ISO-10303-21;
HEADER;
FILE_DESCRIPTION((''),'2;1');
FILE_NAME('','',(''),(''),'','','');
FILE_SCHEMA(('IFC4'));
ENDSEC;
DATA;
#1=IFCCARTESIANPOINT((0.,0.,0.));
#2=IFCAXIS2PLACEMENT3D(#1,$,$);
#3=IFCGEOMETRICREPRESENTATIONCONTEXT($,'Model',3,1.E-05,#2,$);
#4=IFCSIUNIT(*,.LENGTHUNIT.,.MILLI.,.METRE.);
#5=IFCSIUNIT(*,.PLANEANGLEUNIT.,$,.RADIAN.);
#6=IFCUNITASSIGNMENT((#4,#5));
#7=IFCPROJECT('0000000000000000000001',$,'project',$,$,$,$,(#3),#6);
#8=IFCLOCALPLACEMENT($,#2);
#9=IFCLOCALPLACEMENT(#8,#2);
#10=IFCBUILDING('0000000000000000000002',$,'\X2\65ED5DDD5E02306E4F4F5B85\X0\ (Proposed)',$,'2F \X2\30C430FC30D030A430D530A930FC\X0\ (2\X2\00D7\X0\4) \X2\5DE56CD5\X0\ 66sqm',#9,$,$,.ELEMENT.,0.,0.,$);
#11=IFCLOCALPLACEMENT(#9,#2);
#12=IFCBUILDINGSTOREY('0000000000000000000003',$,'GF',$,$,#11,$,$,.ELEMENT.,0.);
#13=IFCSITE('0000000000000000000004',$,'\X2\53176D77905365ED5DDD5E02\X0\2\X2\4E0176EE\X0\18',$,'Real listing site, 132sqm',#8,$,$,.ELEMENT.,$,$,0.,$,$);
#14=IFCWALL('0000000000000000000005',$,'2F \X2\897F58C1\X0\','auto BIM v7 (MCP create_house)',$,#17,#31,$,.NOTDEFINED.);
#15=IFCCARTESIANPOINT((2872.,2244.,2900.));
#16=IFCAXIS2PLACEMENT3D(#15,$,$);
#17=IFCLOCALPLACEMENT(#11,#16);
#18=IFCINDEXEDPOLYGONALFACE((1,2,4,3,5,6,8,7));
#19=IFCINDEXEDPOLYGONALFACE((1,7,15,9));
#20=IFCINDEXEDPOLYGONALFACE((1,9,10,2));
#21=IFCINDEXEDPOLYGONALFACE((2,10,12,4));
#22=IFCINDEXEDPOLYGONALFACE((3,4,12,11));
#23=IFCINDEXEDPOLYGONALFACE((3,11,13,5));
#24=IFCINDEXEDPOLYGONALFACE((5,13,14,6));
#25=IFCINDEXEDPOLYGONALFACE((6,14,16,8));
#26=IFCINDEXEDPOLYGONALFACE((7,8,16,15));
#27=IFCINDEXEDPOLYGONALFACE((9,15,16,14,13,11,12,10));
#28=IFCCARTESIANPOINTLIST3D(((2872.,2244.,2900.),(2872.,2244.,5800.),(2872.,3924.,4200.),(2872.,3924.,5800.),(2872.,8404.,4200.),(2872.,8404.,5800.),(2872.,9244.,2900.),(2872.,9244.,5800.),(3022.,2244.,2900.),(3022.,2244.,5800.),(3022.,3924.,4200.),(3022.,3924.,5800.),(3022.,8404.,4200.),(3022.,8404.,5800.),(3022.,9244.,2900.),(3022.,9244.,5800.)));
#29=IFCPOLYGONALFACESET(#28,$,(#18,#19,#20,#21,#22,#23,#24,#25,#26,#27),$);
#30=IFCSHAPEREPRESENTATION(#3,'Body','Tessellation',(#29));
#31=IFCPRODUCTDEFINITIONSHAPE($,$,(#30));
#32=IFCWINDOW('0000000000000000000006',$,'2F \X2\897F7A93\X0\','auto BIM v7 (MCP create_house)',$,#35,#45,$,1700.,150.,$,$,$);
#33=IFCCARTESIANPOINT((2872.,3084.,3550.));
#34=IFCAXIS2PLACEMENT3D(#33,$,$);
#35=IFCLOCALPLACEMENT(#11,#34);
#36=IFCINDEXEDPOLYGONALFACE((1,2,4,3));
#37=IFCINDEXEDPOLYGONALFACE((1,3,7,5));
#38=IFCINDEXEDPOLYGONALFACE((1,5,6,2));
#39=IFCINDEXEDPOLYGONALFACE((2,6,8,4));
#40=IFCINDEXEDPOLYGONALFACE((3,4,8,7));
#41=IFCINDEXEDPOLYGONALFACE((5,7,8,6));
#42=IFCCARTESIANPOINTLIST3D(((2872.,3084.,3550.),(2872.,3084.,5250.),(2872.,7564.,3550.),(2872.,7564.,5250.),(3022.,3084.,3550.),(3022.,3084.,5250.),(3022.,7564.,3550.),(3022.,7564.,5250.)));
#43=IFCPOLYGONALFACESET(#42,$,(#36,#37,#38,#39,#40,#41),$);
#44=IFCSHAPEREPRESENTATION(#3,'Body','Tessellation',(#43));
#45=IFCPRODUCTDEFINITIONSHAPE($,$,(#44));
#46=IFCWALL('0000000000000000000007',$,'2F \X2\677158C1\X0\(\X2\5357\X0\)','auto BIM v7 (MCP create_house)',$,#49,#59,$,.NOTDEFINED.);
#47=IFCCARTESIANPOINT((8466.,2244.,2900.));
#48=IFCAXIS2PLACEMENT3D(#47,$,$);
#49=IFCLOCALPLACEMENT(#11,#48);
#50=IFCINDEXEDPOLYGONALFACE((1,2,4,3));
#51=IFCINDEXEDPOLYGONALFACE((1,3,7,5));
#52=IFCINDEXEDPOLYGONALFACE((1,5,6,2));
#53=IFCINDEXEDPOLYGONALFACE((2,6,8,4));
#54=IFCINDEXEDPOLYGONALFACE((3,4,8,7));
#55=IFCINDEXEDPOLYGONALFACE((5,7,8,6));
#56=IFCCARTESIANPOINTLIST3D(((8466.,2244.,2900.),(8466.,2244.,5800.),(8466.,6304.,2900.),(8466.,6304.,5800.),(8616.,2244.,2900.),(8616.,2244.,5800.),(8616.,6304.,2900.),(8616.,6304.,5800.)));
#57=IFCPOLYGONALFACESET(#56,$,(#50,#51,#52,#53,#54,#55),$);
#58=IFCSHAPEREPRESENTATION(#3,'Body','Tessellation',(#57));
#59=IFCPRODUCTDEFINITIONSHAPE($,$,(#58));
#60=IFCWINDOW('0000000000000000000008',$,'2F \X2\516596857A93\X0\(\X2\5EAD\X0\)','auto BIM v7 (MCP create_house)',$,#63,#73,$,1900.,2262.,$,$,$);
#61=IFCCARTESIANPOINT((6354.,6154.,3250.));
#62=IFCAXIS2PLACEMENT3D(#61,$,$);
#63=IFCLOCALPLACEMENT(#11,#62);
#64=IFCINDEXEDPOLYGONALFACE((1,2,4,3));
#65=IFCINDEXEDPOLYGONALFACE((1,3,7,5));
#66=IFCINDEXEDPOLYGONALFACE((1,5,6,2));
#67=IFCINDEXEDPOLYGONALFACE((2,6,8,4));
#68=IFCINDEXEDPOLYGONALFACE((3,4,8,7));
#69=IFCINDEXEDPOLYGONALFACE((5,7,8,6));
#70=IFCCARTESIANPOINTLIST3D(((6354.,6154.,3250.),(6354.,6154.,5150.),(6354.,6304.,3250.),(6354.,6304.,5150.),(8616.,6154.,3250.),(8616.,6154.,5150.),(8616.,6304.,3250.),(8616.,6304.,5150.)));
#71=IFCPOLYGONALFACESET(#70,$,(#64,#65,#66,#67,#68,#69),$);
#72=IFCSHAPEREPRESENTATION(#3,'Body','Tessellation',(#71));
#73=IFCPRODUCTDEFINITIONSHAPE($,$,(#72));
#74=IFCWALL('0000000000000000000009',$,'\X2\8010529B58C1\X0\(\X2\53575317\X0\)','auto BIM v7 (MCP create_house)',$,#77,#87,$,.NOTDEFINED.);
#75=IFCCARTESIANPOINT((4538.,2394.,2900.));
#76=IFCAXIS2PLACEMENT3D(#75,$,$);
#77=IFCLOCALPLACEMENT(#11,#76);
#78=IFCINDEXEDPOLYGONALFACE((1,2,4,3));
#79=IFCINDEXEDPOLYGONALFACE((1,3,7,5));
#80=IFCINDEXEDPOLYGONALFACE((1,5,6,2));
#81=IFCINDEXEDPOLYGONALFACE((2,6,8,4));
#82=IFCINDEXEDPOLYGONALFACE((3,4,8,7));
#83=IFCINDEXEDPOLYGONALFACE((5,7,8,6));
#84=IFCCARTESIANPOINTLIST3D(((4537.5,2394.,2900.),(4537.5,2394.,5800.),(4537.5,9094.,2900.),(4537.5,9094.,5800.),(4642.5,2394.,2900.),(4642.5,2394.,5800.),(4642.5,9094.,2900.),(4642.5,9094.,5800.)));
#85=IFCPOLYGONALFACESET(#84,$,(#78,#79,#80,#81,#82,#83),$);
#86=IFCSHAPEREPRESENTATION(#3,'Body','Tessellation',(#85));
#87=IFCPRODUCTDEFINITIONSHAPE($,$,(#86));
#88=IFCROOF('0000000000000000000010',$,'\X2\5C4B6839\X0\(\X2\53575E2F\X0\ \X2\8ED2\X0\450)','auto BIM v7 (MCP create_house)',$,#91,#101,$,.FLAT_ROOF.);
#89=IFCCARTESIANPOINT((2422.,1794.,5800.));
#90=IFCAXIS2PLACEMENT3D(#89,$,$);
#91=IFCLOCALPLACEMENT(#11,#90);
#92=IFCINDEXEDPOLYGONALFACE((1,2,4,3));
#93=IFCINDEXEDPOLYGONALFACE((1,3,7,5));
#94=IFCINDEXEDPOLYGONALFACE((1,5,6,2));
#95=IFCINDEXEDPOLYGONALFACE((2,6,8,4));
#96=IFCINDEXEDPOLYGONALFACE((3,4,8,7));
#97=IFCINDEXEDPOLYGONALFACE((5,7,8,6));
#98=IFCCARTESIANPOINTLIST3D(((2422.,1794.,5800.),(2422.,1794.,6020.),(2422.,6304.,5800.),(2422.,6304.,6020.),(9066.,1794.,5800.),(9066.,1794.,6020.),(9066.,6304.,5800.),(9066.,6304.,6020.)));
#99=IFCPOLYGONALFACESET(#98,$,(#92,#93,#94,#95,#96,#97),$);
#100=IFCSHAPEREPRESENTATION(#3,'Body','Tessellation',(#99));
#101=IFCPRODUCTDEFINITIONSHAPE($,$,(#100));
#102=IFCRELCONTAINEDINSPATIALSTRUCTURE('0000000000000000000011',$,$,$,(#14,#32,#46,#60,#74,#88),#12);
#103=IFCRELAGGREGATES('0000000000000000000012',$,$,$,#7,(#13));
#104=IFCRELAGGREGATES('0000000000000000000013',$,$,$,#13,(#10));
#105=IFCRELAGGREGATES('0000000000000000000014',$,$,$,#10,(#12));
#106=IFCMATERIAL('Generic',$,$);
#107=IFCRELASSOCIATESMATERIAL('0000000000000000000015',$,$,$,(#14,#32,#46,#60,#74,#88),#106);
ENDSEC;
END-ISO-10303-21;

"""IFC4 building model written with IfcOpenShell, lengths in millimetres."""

from ifc_helpers import new_model, si_unit, frame, frame_2d, origin, place, context, project, spatial, rectangle, extrude, material, element, fill, save


model = new_model("IFC4")

# Units and contexts
model_context = context("Model", 3, precision=1e-05, world=origin())
ifc_project = project(units=[si_unit("LENGTHUNIT", "METRE", prefix="MILLI"), si_unit("PLANEANGLEUNIT", "RADIAN")], contexts=[model_context])

# Site, building, storey
site_placement = place(None, origin())
site = spatial("IfcSite", under=ifc_project, at=site_placement, Name="北海道旭川市2丁目18", ObjectType="Real listing site, 132sqm", CompositionType="ELEMENT", RefElevation=0.0)
building_placement = place(site_placement, origin())
building = spatial("IfcBuilding", under=site, at=building_placement, Name="旭川市の住宅 (Proposed)", ObjectType="2F ツーバイフォー (2×4) 工法 66sqm", CompositionType="ELEMENT", ElevationOfRefHeight=0.0, ElevationOfTerrain=0.0)
storey_placement = place(building_placement, origin())
storey = spatial("IfcBuildingStorey", under=building, at=storey_placement, Name="GF", CompositionType="ELEMENT", Elevation=0.0)

# Shared definitions
ifc_material = material(Name="Generic")

# Walls, openings, windows
wall_1_placement = place(storey_placement, frame((2872.0, 2244.0, 2900.0)))
wall_1 = element("IfcWall", 1, at=wall_1_placement, inside=storey, material=ifc_material, Name="2F 西壁", Description="auto BIM v7 (MCP create_house)", PredefinedType="NOTDEFINED", context=model_context, shape_type="SweptSolid", body=[
    extrude(rectangle(XDim=150.0, YDim=7000.0, at=frame_2d((75.0, 3500.0))), frame((2872.0, 2244.0, 2900.0)), (0.0, 0.0, 1.0), 2900.0),
])
opening_1_placement = place(storey_placement, frame((2872.0, 3084.0, 3550.0)))
opening_1 = element("IfcOpeningElement", 2, at=opening_1_placement, cuts=wall_1, PredefinedType="NOTDEFINED", context=model_context, shape_type="SweptSolid", body=[
    extrude(rectangle(XDim=150.0, YDim=4480.0, at=frame_2d((75.0, 2240.0))), frame((2872.0, 3084.0, 3550.0)), (0.0, 0.0, 1.0), 1700.0),
])
window_1_placement = place(storey_placement, frame((2872.0, 3084.0, 3550.0)))
window_1 = element("IfcWindow", 3, at=window_1_placement, inside=storey, material=ifc_material, Name="2F 西窓", Description="auto BIM v7 (MCP create_house)", OverallHeight=1700.0, OverallWidth=150.0, context=model_context, shape_type="SweptSolid", body=[
    extrude(rectangle(XDim=150.0, YDim=4480.0, at=frame_2d((75.0, 2240.0))), frame((2872.0, 3084.0, 3550.0)), (0.0, 0.0, 1.0), 1700.0),
])
fill(opening_1, window_1)
wall_2_placement = place(storey_placement, frame((8466.0, 2244.0, 2900.0)))
wall_2 = element("IfcWall", 4, at=wall_2_placement, inside=storey, material=ifc_material, Name="2F 東壁(南)", Description="auto BIM v7 (MCP create_house)", PredefinedType="NOTDEFINED", context=model_context, shape_type="SweptSolid", body=[
    extrude(rectangle(XDim=150.0, YDim=4060.0, at=frame_2d((75.0, 2030.0))), frame((8466.0, 2244.0, 2900.0)), (0.0, 0.0, 1.0), 2900.0),
])
opening_2_placement = place(storey_placement, frame((6354.0, 6154.0, 3250.0)))
opening_2 = element("IfcOpeningElement", 5, at=opening_2_placement, cuts=wall_2, PredefinedType="NOTDEFINED", context=model_context, shape_type="SweptSolid", body=[
    extrude(rectangle(XDim=2262.0, YDim=150.0, at=frame_2d((1131.0, 75.0))), frame((6354.0, 6154.0, 3250.0)), (0.0, 0.0, 1.0), 1900.0),
])
window_2_placement = place(storey_placement, frame((6354.0, 6154.0, 3250.0)))
window_2 = element("IfcWindow", 6, at=window_2_placement, inside=storey, material=ifc_material, Name="2F 入隅窓(庭)", Description="auto BIM v7 (MCP create_house)", OverallHeight=1900.0, OverallWidth=2262.0, context=model_context, shape_type="SweptSolid", body=[
    extrude(rectangle(XDim=2262.0, YDim=150.0, at=frame_2d((1131.0, 75.0))), frame((6354.0, 6154.0, 3250.0)), (0.0, 0.0, 1.0), 1900.0),
])
fill(opening_2, window_2)

# Wall
wall_3_placement = place(storey_placement, frame((4538.0, 2394.0, 2900.0)))
element("IfcWall", 7, at=wall_3_placement, inside=storey, material=ifc_material, Name="耐力壁(南北)", Description="auto BIM v7 (MCP create_house)", PredefinedType="NOTDEFINED", context=model_context, shape_type="SweptSolid", body=[
    extrude(rectangle(XDim=105.0, YDim=6700.0, at=frame_2d((52.0, 3350.0))), frame((4538.0, 2394.0, 2900.0)), (0.0, 0.0, 1.0), 2900.0),
])

# Roof
for number, where, name in (
    (8, (2422.0, 1794.0, 5800.0), "屋根(南帯 軒450)"),
):
    element("IfcRoof", number, at=place(storey_placement, frame(where)), inside=storey, material=ifc_material, Name=name, Description="auto BIM v7 (MCP create_house)", PredefinedType="FLAT_ROOF", context=model_context, shape_type="SweptSolid", body=[
        extrude(rectangle(XDim=6644.0, YDim=4510.0, at=frame_2d((3322.0, 2255.0))), frame((2422.0, 1794.0, 5800.0)), (0.0, 0.0, 1.0), 220.0),
    ])

save(model, "model.ifc")
